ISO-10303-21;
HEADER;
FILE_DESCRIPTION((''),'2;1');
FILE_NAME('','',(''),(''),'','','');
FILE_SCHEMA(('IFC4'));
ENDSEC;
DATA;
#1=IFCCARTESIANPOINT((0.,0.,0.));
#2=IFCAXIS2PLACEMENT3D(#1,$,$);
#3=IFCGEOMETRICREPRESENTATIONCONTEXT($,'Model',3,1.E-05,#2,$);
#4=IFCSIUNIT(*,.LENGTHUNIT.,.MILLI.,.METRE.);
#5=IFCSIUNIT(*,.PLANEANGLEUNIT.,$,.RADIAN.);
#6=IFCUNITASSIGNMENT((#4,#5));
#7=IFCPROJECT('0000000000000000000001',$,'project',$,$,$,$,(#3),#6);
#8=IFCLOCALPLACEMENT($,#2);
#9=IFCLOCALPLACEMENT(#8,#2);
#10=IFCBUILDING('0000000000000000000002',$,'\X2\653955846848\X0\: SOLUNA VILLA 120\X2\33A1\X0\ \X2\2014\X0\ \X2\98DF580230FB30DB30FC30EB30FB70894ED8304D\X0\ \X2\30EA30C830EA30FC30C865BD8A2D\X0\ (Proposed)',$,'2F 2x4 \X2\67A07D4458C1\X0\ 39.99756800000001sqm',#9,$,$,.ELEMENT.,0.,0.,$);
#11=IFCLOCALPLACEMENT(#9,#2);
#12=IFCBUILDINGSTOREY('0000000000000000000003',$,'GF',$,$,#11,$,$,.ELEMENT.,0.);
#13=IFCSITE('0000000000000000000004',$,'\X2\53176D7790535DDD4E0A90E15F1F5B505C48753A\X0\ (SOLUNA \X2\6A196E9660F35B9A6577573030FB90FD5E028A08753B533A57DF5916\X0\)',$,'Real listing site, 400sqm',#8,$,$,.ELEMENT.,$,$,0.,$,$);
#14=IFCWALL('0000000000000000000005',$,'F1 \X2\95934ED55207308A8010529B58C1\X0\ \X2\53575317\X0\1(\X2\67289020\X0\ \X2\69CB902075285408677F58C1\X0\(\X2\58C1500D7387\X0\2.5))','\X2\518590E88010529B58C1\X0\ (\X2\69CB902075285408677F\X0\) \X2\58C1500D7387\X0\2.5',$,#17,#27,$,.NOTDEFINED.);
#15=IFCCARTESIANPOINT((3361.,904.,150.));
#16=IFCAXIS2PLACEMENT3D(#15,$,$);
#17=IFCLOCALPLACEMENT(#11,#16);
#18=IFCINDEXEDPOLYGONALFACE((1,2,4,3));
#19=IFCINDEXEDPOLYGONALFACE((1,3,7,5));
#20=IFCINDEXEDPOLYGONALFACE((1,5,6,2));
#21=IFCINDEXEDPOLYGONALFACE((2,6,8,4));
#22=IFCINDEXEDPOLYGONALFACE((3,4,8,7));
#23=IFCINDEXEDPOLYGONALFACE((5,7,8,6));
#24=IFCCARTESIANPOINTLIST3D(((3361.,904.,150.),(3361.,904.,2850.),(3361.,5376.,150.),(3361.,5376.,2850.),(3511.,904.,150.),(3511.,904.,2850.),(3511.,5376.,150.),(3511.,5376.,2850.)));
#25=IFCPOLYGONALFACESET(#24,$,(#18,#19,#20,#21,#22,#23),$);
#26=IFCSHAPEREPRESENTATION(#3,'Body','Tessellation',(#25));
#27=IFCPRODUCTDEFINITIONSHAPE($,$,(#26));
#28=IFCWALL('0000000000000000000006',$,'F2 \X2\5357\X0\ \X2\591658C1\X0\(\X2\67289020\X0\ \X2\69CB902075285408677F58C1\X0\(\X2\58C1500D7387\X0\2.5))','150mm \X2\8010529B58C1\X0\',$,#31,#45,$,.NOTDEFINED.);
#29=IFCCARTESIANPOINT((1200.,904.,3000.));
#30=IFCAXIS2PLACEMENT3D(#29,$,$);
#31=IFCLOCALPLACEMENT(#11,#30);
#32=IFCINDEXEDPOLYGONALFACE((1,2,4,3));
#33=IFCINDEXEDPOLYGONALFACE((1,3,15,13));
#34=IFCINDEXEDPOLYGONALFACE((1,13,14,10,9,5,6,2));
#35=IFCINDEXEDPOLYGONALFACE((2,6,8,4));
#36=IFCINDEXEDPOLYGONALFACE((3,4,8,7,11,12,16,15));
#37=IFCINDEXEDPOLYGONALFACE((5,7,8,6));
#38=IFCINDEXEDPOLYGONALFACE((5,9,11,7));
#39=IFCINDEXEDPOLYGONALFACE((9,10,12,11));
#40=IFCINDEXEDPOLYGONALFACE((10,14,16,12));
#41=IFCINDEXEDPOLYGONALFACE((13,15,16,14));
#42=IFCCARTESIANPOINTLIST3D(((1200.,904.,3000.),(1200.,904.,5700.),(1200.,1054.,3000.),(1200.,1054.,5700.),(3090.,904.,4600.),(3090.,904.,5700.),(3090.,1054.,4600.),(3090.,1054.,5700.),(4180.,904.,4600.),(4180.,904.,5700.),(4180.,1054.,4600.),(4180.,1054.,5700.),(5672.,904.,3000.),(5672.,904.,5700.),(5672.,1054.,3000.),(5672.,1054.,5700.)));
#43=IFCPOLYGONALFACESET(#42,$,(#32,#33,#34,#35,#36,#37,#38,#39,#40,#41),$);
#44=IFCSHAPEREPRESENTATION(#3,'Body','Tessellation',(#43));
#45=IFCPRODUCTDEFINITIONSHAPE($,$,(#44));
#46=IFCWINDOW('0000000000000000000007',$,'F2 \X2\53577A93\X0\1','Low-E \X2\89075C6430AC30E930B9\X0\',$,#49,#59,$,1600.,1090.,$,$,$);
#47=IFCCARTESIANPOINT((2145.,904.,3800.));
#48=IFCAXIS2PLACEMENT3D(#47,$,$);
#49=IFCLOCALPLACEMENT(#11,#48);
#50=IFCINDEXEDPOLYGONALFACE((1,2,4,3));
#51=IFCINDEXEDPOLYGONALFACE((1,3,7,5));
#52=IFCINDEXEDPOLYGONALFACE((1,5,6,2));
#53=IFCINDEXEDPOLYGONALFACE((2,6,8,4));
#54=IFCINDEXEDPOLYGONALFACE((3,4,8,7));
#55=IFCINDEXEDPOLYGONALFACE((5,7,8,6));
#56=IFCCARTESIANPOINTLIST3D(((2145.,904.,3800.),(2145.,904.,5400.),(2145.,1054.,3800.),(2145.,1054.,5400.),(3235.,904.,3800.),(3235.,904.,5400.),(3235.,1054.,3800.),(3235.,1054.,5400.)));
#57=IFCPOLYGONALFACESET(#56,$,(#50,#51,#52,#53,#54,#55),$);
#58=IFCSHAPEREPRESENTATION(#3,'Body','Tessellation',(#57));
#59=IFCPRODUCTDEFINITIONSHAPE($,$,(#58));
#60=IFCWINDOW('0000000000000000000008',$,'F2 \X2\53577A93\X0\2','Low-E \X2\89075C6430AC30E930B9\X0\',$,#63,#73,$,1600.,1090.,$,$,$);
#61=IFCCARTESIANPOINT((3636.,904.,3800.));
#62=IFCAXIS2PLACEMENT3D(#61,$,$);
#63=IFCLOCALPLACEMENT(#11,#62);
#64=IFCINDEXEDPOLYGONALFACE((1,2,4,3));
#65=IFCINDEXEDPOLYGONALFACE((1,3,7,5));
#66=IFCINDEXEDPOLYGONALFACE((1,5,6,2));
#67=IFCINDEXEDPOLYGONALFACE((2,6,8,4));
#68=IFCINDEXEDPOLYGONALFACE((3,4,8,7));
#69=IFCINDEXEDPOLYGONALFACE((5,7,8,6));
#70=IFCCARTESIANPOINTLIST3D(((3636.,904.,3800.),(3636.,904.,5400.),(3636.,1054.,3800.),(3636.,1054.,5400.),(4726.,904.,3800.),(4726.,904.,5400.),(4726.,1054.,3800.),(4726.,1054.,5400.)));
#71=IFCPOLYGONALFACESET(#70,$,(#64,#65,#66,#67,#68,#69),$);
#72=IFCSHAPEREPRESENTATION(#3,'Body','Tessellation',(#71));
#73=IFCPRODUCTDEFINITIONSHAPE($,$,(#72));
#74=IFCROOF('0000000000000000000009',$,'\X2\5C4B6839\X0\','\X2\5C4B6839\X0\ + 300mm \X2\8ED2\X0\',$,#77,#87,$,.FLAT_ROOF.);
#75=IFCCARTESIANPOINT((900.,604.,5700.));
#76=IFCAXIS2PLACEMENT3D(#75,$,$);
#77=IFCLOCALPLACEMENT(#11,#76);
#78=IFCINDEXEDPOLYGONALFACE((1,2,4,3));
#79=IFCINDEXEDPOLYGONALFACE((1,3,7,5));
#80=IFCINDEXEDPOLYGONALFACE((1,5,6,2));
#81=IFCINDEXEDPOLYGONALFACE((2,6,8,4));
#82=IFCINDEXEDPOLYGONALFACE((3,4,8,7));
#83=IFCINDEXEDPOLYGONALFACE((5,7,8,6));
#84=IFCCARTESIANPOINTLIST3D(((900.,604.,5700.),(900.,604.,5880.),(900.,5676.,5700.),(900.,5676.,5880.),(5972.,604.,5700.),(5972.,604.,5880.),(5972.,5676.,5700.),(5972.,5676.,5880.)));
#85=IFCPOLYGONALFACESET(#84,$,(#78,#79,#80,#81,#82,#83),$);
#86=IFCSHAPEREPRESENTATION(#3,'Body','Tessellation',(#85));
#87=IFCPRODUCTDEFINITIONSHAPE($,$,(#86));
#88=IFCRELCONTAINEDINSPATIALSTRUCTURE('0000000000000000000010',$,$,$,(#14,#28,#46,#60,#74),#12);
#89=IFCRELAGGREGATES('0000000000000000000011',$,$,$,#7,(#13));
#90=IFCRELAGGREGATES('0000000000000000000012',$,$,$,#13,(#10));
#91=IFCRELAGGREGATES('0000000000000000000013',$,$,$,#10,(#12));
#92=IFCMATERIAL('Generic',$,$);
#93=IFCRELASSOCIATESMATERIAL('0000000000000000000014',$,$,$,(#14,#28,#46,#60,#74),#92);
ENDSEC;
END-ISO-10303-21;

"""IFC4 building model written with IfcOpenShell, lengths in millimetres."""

from ifc_helpers import new_model, si_unit, frame, frame_2d, origin, place, context, project, spatial, rectangle, extrude, material, element, fill, save


model = new_model("IFC4")

# Units and contexts
model_context = context("Model", 3, precision=1e-05, world=origin())
ifc_project = project(units=[si_unit("LENGTHUNIT", "METRE", prefix="MILLI"), si_unit("PLANEANGLEUNIT", "RADIAN")], contexts=[model_context])

# Site, building, storey
site_placement = place(None, origin())
site = spatial("IfcSite", under=ifc_project, at=site_placement, Name="北海道川上郡弟子屈町 (SOLUNA 標準想定敷地・都市計画区域外)", ObjectType="Real listing site, 400sqm", CompositionType="ELEMENT", RefElevation=0.0)
building_placement = place(site_placement, origin())
building = spatial("IfcBuilding", under=site, at=building_placement, Name="改善案: SOLUNA VILLA 120㎡ — 食堂・ホール・炉付き リトリート施設 (Proposed)", ObjectType="2F 2x4 枠組壁 39.99756800000001sqm", CompositionType="ELEMENT", ElevationOfRefHeight=0.0, ElevationOfTerrain=0.0)
storey_placement = place(building_placement, origin())
storey = spatial("IfcBuildingStorey", under=building, at=storey_placement, Name="GF", CompositionType="ELEMENT", Elevation=0.0)

# Shared definitions
ifc_material_1 = material(Name="Generic")

# Wall
wall_1_placement = place(storey_placement, frame((3361.0, 904.0, 150.0)))
element("IfcWall", 1, at=wall_1_placement, inside=storey, material=ifc_material_1, Name="F1 間仕切り耐力壁 南北1(木造 構造用合板壁(壁倍率2.5))", Description="内部耐力壁 (構造用合板) 壁倍率2.5", PredefinedType="NOTDEFINED", context=model_context, shape_type="SweptSolid", body=[
    extrude(rectangle(XDim=150.0, YDim=4472.0, at=frame_2d((75.0, 2236.0))), frame((3361.0, 904.0, 150.0)), (0.0, 0.0, 1.0), 2700.0),
])

# Wall, openings, windows
wall_2_placement = place(storey_placement, frame((1200.0, 904.0, 3000.0)))
wall_2 = element("IfcWall", 2, at=wall_2_placement, inside=storey, material=ifc_material_1, Name="F2 南 外壁(木造 構造用合板壁(壁倍率2.5))", Description="150mm 耐力壁", PredefinedType="NOTDEFINED", context=model_context, shape_type="SweptSolid", body=[
    extrude(rectangle(XDim=4472.0, YDim=150.0, at=frame_2d((2236.0, 75.0))), frame((1200.0, 904.0, 3000.0)), (0.0, 0.0, 1.0), 2700.0),
])
opening_1_placement = place(storey_placement, frame((2145.0, 904.0, 3800.0)))
opening_1 = element("IfcOpeningElement", 3, at=opening_1_placement, cuts=wall_2, PredefinedType="NOTDEFINED", context=model_context, shape_type="SweptSolid", body=[
    extrude(rectangle(XDim=1090.0, YDim=150.0, at=frame_2d((545.0, 75.0))), frame((2145.0, 904.0, 3800.0)), (0.0, 0.0, 1.0), 1600.0),
])
opening_2_placement = place(storey_placement, frame((3636.0, 904.0, 3800.0)))
opening_2 = element("IfcOpeningElement", 4, at=opening_2_placement, cuts=wall_2, PredefinedType="NOTDEFINED", context=model_context, shape_type="SweptSolid", body=[
    extrude(rectangle(XDim=1090.0, YDim=150.0, at=frame_2d((545.0, 75.0))), frame((3636.0, 904.0, 3800.0)), (0.0, 0.0, 1.0), 1600.0),
])
window_1_placement = place(storey_placement, frame((2145.0, 904.0, 3800.0)))
window_1 = element("IfcWindow", 5, at=window_1_placement, inside=storey, material=ifc_material_1, Name="F2 南窓1", Description="Low-E 複層ガラス", OverallHeight=1600.0, OverallWidth=1090.0, context=model_context, shape_type="SweptSolid", body=[
    extrude(rectangle(XDim=1090.0, YDim=150.0, at=frame_2d((545.0, 75.0))), frame((2145.0, 904.0, 3800.0)), (0.0, 0.0, 1.0), 1600.0),
])
fill(opening_1, window_1)
window_2_placement = place(storey_placement, frame((3636.0, 904.0, 3800.0)))
window_2 = element("IfcWindow", 6, at=window_2_placement, inside=storey, material=ifc_material_1, Name="F2 南窓2", Description="Low-E 複層ガラス", OverallHeight=1600.0, OverallWidth=1090.0, context=model_context, shape_type="SweptSolid", body=[
    extrude(rectangle(XDim=1090.0, YDim=150.0, at=frame_2d((545.0, 75.0))), frame((3636.0, 904.0, 3800.0)), (0.0, 0.0, 1.0), 1600.0),
])
fill(opening_2, window_2)

# Roof
roof_placement = place(storey_placement, frame((900.0, 604.0, 5700.0)))
element("IfcRoof", 7, at=roof_placement, inside=storey, material=ifc_material_1, Name="屋根", Description="屋根 + 300mm 軒", PredefinedType="FLAT_ROOF", context=model_context, shape_type="SweptSolid", body=[
    extrude(rectangle(XDim=5072.0, YDim=5072.0, at=frame_2d((2536.0, 2536.0))), frame((900.0, 604.0, 5700.0)), (0.0, 0.0, 1.0), 180.0),
])

save(model, "model.ifc")
